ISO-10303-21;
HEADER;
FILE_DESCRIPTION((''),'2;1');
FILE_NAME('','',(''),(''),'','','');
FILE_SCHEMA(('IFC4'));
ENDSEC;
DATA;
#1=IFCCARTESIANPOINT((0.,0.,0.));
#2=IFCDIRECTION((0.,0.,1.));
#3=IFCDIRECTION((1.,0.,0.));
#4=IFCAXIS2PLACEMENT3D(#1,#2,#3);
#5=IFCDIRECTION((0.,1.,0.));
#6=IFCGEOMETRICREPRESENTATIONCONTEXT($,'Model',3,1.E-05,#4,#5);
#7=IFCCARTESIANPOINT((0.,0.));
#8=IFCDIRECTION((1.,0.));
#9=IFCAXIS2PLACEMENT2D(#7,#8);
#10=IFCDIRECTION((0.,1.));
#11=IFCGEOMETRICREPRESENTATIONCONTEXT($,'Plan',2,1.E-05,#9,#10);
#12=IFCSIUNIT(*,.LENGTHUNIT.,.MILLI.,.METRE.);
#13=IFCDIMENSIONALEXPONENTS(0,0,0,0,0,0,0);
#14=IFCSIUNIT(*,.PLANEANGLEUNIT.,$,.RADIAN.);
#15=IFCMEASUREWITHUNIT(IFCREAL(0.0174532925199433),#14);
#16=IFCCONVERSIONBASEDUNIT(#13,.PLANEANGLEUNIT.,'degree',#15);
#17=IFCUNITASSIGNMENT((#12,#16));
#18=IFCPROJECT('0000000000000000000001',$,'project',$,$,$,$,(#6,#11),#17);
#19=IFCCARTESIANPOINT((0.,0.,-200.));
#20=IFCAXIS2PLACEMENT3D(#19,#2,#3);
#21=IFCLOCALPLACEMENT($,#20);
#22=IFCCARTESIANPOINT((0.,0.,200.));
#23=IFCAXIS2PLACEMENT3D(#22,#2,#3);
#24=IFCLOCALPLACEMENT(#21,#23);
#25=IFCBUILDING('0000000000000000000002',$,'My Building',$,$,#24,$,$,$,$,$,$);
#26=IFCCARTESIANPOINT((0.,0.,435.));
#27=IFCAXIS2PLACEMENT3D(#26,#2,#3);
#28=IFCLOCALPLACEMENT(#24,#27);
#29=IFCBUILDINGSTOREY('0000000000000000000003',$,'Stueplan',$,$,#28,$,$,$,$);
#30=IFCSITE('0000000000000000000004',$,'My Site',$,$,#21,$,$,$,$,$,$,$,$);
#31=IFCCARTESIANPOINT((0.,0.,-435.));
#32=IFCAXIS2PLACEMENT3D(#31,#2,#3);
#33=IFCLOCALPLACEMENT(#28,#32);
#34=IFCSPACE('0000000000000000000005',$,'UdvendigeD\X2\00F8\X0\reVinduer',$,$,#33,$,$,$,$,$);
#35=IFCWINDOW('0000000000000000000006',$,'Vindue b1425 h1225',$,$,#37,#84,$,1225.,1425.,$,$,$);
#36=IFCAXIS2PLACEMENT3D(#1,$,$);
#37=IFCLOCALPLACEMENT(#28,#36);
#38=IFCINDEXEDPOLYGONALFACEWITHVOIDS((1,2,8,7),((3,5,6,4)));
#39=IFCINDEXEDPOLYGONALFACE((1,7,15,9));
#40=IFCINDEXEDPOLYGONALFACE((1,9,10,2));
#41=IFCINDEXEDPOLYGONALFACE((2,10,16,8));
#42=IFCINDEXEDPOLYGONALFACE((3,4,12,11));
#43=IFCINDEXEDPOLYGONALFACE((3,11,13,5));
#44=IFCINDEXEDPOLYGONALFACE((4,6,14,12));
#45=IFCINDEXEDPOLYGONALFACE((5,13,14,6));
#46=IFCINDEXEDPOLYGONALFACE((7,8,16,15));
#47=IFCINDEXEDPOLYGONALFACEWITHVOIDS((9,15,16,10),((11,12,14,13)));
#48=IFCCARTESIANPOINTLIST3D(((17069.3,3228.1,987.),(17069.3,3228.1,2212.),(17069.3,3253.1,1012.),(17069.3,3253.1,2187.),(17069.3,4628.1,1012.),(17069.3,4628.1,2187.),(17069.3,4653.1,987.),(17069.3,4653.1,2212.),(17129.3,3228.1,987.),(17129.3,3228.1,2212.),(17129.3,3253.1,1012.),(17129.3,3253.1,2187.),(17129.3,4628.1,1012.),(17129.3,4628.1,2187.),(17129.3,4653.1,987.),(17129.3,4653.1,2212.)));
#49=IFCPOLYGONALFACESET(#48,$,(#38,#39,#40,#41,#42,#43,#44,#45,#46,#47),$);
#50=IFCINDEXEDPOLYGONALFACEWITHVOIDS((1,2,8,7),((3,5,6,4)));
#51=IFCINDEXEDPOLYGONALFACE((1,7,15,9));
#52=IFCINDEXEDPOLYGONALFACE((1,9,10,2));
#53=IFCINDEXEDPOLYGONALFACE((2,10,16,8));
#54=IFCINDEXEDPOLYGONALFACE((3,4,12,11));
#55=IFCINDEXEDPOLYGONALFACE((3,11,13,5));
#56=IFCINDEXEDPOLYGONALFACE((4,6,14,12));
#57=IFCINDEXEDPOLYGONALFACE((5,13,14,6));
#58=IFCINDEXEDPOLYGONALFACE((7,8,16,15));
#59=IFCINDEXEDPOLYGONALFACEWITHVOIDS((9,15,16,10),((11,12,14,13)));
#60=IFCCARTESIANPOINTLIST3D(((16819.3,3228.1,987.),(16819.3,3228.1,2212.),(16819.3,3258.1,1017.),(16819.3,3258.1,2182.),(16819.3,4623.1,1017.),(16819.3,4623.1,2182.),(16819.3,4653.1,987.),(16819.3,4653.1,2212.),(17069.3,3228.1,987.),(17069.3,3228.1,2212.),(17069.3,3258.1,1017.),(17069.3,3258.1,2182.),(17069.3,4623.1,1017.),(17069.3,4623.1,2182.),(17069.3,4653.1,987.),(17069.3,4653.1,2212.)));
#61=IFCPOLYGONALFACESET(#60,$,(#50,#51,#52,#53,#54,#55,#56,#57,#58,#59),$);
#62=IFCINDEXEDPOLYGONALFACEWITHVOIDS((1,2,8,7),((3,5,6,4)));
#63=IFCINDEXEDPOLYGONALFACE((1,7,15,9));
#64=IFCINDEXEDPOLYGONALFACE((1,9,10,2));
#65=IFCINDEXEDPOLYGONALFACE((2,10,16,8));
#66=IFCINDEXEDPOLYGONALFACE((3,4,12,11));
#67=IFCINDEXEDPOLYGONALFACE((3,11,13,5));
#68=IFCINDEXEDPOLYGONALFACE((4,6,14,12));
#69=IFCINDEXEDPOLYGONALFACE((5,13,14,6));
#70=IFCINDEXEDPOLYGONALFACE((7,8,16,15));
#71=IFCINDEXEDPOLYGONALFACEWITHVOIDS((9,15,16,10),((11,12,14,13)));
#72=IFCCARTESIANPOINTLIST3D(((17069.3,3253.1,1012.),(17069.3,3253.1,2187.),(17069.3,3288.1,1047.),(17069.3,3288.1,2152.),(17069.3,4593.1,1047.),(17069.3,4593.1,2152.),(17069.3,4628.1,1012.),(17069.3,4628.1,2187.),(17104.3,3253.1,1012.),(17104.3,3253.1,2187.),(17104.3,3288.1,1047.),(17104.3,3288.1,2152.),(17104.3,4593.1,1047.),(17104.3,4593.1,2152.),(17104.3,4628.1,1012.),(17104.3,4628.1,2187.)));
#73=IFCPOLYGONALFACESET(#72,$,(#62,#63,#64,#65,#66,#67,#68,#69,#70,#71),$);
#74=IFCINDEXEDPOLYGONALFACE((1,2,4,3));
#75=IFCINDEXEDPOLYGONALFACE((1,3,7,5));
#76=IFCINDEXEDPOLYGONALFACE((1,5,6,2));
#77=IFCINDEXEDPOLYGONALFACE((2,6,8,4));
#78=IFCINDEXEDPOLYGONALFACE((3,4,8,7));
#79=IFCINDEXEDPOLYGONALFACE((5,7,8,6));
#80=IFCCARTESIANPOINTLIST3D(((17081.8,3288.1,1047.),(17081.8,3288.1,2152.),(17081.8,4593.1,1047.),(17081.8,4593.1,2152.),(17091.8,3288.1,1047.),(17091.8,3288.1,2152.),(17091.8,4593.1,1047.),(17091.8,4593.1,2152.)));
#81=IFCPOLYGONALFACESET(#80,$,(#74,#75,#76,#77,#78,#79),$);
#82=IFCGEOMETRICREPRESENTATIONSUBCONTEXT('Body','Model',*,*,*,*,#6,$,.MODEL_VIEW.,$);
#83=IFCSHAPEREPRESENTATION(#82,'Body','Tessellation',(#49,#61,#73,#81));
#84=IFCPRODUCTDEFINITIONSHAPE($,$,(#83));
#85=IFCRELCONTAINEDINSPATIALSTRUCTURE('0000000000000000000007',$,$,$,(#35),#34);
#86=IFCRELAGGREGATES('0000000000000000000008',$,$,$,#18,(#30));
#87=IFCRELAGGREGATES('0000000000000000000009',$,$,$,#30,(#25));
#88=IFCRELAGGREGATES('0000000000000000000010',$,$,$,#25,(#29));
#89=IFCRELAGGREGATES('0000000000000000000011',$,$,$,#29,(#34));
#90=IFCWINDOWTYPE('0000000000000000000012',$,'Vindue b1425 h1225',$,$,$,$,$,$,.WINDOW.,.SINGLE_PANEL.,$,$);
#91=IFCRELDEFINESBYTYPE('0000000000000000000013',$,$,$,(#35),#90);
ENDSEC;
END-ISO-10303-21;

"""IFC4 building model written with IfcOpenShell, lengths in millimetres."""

from ifc_helpers import new_model, entity, si_unit, converted_unit, direction, frame, origin_with_axes, origin_2d_with_axis, place, context, subcontext, project, spatial, line, indexed_curve, outline, extrude, shape, source, transform, mapped, type_object, type_shapes, element, save


model = new_model("IFC4")

# Units and contexts
model_context = context("Model", 3, precision=1e-05, world=origin_with_axes(), true_north=direction((0.0, 1.0, 0.0)))
plan_context = context("Plan", 2, precision=1e-05, world=origin_2d_with_axis(), true_north=direction((0.0, 1.0)))
body_context_1 = subcontext(model_context, "Body", "Model", "MODEL_VIEW")
body_context_2 = subcontext(plan_context, "Body", "Plan", "PLAN_VIEW")
ifc_project = project(units=[si_unit("LENGTHUNIT", "METRE", prefix="MILLI"), converted_unit("PLANEANGLEUNIT", "degree", entity("IfcReal", 0.0174532925199433), si_unit("PLANEANGLEUNIT", "RADIAN"), dimensions=[0, 0, 0, 0, 0, 0, 0])], contexts=[model_context, plan_context])

# Site, building, storey
site_placement = place(None, frame((0.0, 0.0, -200.0), z_axis=(0.0, 0.0, 1.0), x_axis=(1.0, 0.0, 0.0)))
site = spatial("IfcSite", under=ifc_project, at=site_placement, Name="My Site")
building_placement = place(site_placement, frame((0.0, 0.0, 200.0), z_axis=(0.0, 0.0, 1.0), x_axis=(1.0, 0.0, 0.0)))
building = spatial("IfcBuilding", under=site, at=building_placement, Name="My Building")
storey_placement = place(building_placement, frame((0.0, 0.0, 435.0), z_axis=(0.0, 0.0, 1.0), x_axis=(1.0, 0.0, 0.0)))
storey = spatial("IfcBuildingStorey", under=building, at=storey_placement, Name="Stueplan")

# Shared definitions
space_1_placement = place(storey_placement, frame((0.0, 0.0, -435.0), z_axis=(0.0, 0.0, 1.0), x_axis=(1.0, 0.0, 0.0)))
space_1 = spatial("IfcSpace", under=storey, at=space_1_placement, Name="UdvendigeDøreVinduer")

# Window
window_type = type_object("IfcWindowType", Name="Vindue b1425 h1225", PartitioningType="SINGLE_PANEL", PredefinedType="WINDOW")
shared_shape_1 = source(origin_with_axes(), body_context_1, "Body", "SweptSolid", [
    extrude(outline(indexed_curve([(0.0, 0.0), (1425.0, 0.0), (1425.0, 1225.0), (0.0, 1225.0)], segments=[line(1, 2, 3, 4, 1)]), holes=[indexed_curve([(25.0, 25.0), (1400.0, 25.0), (1400.0, 1200.0), (25.0, 1200.0)], segments=[line(1, 2, 3, 4, 1)])]), frame((0.0, 250.0, 0.0), z_axis=(0.0, -1.0, 0.0), x_axis=(1.0, 0.0, 0.0)), (0.0, 0.0, -1.0), 60.0),
    extrude(outline(indexed_curve([(0.0, 0.0), (1425.0, 0.0), (1425.0, 1225.0), (0.0, 1225.0)], segments=[line(1, 2, 3, 4, 1)]), holes=[indexed_curve([(30.0, 30.0), (1395.0, 30.0), (1395.0, 1195.0), (30.0, 1195.0)], segments=[line(1, 2, 3, 4, 1)])]), frame((0.0, 0.0, 0.0), z_axis=(0.0, -1.0, 0.0), x_axis=(1.0, 0.0, 0.0)), (0.0, 0.0, -1.0), 250.0),
    extrude(outline(indexed_curve([(0.0, 0.0), (1375.0, 0.0), (1375.0, 1175.0), (0.0, 1175.0)], segments=[line(1, 2, 3, 4, 1)]), holes=[indexed_curve([(35.0, 35.0), (1340.0, 35.0), (1340.0, 1140.0), (35.0, 1140.0)], segments=[line(1, 2, 3, 4, 1)])]), frame((25.0, 250.0, 25.0), z_axis=(0.0, -1.0, 0.0), x_axis=(1.0, 0.0, 0.0)), (0.0, 0.0, -1.0), 35.0),
    extrude(outline(indexed_curve([(35.0, 35.0), (1340.0, 35.0), (1340.0, 1140.0), (35.0, 1140.0)], segments=[line(1, 2, 3, 4, 1)])), frame((25.0, 262.5, 25.0), z_axis=(0.0, -1.0, 0.0), x_axis=(1.0, 0.0, 0.0)), (0.0, 0.0, -1.0), 10.0),
])
shared_shape_2 = source(origin_with_axes(), body_context_2, "Body", "Curve2D", [
    entity("IfcIndexedPolyCurve", entity("IfcCartesianPointList2D", [[30.0, 0.0], [1395.0, 0.0]])),
    entity("IfcIndexedPolyCurve", entity("IfcCartesianPointList2D", [[0.0, 310.0], [25.0, 310.0], [25.0, 250.0], [30.0, 250.0], [30.0, 0.0], [0.0, 0.0]]), [entity("IfcLineIndex", [1, 2, 3, 4, 5, 6, 1])]),
    entity("IfcIndexedPolyCurve", entity("IfcCartesianPointList2D", [[1425.0, 310.0], [1400.0, 310.0], [1400.0, 250.0], [1395.0, 250.0], [1395.0, 0.0], [1425.0, 0.0]]), [entity("IfcLineIndex", [1, 2, 3, 4, 5, 6, 1])]),
    entity("IfcIndexedPolyCurve", entity("IfcCartesianPointList2D", [[25.0, 250.0], [60.0, 250.0], [60.0, 285.0], [25.0, 285.0]]), [entity("IfcLineIndex", [1, 2, 3, 4, 1])]),
    entity("IfcIndexedPolyCurve", entity("IfcCartesianPointList2D", [[1400.0, 250.0], [1365.0, 250.0], [1365.0, 285.0], [1400.0, 285.0]]), [entity("IfcLineIndex", [1, 2, 3, 4, 1])]),
    entity("IfcIndexedPolyCurve", entity("IfcCartesianPointList2D", [[60.0, 250.0], [1365.0, 250.0]])),
    entity("IfcIndexedPolyCurve", entity("IfcCartesianPointList2D", [[60.0, 285.0], [1365.0, 285.0]])),
    entity("IfcIndexedPolyCurve", entity("IfcCartesianPointList2D", [[60.0, 267.5], [1365.0, 267.5]])),
])
type_shapes(window_type, [shared_shape_1, shared_shape_2])
for number, where, z_axis, x_axis, name in (
    (1, (16819.3, 4653.1, 1422.0), (0.0, 0.0, 1.0), (0.0, -1.0, 0.0), "Vindue b1425 h1225"),
):
    element("IfcWindow", number, at=place(space_1_placement, frame(where, z_axis=z_axis, x_axis=x_axis)), inside=space_1, type_object=window_type, Name=name, OverallHeight=1225.0, OverallWidth=1425.0, shapes=[
        shape(body_context_1, "Body", "MappedRepresentation", [mapped(shared_shape_1, transform((0.0, 0.0, 0.0), x_axis=(1.0, 0.0, 0.0), y_axis=(0.0, 1.0, 0.0), z_axis=(0.0, 0.0, 1.0), scale=1.0))]),
        shape(body_context_2, "Body", "MappedRepresentation", [mapped(shared_shape_2, transform((0.0, 0.0, 0.0), x_axis=(1.0, 0.0, 0.0), y_axis=(0.0, 1.0, 0.0), z_axis=(0.0, 0.0, 1.0), scale=1.0))]),
    ])

save(model, "model.ifc")
